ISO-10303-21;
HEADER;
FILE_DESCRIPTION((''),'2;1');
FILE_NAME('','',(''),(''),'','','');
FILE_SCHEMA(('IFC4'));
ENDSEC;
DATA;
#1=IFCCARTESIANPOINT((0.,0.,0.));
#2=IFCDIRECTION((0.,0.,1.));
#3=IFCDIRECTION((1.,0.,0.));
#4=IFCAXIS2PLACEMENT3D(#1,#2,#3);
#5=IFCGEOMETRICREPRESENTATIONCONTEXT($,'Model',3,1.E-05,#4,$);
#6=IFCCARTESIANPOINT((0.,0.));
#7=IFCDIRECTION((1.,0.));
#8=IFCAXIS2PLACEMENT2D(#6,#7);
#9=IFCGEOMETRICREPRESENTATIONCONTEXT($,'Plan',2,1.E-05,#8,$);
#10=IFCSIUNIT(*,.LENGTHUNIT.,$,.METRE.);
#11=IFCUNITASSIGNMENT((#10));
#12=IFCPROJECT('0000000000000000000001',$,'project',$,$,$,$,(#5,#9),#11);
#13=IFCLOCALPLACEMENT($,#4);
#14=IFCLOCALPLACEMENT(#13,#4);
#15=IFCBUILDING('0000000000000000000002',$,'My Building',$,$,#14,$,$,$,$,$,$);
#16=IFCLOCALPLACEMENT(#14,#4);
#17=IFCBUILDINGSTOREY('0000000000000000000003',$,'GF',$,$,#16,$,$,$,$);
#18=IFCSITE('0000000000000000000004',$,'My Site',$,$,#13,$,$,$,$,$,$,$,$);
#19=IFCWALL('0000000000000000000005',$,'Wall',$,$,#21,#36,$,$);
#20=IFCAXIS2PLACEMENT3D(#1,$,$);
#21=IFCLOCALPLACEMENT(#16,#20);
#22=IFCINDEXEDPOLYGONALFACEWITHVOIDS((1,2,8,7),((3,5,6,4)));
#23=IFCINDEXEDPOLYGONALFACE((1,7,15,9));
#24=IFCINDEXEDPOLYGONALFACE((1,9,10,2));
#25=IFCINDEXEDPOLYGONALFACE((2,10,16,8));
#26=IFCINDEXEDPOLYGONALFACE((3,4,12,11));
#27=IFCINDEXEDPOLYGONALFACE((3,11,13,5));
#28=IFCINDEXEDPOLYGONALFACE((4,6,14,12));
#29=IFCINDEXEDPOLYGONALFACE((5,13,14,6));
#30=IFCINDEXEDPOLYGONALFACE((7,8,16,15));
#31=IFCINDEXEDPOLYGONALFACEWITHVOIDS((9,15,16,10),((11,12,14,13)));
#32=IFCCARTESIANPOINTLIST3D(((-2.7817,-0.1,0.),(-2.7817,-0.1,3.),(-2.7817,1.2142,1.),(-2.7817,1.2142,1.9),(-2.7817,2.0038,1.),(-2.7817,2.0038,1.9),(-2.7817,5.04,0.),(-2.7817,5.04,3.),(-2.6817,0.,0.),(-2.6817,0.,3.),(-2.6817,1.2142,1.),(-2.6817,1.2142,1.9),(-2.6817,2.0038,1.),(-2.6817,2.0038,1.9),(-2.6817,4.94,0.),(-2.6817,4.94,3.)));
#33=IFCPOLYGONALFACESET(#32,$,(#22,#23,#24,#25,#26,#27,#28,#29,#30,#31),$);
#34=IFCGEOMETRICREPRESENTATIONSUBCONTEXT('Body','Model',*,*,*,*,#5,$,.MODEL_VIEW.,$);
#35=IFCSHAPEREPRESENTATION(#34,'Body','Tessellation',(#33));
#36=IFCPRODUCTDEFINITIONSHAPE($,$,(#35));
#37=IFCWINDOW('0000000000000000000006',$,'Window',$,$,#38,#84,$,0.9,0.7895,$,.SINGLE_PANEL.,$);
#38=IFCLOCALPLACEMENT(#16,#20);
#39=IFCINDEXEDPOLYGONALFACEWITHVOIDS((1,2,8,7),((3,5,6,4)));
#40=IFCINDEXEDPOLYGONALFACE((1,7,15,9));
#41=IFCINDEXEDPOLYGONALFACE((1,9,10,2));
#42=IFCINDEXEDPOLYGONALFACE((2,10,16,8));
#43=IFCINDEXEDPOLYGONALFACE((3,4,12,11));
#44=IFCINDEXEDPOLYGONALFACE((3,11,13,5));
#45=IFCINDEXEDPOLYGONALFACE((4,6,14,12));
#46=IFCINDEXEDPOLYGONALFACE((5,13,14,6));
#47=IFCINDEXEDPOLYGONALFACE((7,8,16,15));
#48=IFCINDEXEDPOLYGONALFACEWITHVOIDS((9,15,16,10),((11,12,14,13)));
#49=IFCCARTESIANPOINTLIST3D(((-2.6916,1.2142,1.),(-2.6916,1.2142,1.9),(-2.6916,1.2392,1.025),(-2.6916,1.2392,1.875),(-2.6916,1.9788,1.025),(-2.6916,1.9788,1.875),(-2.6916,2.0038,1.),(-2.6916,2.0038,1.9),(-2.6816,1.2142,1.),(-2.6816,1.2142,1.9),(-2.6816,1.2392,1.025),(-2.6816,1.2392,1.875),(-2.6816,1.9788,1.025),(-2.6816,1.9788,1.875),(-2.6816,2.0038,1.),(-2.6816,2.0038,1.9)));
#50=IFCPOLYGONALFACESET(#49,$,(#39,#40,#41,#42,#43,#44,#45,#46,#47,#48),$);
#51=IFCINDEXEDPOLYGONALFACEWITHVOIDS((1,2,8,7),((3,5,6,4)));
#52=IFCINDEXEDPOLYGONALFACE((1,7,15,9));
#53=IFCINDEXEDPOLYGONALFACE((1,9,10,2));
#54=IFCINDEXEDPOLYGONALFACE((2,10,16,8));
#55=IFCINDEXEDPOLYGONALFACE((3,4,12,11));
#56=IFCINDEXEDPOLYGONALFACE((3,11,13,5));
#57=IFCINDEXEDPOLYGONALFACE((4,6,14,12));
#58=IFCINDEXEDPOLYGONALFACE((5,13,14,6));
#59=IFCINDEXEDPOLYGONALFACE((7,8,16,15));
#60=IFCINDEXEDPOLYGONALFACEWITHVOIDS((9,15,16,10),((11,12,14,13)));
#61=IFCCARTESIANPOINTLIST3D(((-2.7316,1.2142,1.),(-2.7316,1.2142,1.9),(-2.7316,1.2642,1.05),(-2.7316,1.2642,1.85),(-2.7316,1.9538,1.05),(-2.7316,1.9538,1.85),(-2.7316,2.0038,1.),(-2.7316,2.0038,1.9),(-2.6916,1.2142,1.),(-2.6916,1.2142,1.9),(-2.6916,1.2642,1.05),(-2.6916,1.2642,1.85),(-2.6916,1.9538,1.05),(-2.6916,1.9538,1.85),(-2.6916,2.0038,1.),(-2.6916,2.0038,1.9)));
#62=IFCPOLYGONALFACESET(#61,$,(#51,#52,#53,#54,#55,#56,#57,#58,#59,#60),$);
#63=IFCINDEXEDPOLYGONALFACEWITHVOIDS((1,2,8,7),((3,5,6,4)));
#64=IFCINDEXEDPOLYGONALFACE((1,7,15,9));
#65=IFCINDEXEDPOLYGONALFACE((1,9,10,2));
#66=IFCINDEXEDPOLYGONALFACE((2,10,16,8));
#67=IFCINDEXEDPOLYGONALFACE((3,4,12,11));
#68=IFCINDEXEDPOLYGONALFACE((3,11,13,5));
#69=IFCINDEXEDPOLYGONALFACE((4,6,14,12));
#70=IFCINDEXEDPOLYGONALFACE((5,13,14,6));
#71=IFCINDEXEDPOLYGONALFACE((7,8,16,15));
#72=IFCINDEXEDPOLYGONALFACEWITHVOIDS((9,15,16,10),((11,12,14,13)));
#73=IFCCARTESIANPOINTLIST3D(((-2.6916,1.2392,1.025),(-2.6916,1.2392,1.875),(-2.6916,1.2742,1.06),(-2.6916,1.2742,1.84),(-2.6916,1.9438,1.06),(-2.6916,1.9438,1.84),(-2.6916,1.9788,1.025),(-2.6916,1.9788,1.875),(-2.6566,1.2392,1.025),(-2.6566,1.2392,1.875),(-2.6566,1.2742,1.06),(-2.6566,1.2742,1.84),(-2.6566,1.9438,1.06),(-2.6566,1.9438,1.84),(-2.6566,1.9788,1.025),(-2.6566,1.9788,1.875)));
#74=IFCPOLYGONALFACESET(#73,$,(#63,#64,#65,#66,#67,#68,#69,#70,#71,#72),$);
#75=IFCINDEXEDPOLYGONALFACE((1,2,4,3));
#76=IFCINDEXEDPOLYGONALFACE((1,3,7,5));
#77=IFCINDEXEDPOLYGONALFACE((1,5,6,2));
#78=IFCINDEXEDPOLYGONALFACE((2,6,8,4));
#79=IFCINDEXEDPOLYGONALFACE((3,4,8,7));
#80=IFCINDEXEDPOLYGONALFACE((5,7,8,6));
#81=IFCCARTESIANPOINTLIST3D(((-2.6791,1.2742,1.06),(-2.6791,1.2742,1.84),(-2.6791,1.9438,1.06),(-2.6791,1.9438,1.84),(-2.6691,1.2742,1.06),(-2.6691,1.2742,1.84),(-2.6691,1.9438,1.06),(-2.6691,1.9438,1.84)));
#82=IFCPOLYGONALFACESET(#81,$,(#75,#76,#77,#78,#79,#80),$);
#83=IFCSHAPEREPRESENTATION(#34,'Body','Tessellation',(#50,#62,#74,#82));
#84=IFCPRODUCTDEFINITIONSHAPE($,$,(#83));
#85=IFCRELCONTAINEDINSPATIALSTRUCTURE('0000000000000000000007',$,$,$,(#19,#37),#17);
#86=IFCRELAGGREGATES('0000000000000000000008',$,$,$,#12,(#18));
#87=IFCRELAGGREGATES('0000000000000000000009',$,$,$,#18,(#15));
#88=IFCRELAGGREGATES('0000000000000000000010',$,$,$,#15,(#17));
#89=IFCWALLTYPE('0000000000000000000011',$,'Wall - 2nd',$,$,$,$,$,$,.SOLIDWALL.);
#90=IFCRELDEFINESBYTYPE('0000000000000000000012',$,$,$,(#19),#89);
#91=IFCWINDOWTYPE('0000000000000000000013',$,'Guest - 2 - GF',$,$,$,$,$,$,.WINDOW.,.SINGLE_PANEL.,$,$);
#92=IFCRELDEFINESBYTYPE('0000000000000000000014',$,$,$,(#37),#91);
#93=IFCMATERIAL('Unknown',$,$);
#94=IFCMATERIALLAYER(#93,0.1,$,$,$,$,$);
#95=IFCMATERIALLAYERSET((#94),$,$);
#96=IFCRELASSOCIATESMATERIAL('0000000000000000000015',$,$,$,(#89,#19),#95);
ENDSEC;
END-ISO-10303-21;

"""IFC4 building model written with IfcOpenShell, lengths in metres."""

from ifc_helpers import new_model, entity, si_unit, frame, origin_with_axes, origin_2d_with_axis, place, context, subcontext, project, spatial, line, indexed_curve, outline, extrude, shape, source, transform, mapped, material, layer, layer_set, layer_usage, type_object, type_shapes, element, fill, save


model = new_model("IFC4")

# Units and contexts
model_context = context("Model", 3, precision=1e-05, world=origin_with_axes())
plan_context = context("Plan", 2, precision=1e-05, world=origin_2d_with_axis())
body_context_1 = subcontext(model_context, "Body", "Model", "MODEL_VIEW")
body_context_2 = subcontext(plan_context, "Body", "Plan", "PLAN_VIEW")
ifc_project = project(units=[si_unit("LENGTHUNIT", "METRE")], contexts=[model_context, plan_context])

# Site, building, storey
site_placement = place(None, origin_with_axes())
site = spatial("IfcSite", under=ifc_project, at=site_placement, Name="My Site")
building_placement = place(site_placement, origin_with_axes())
building = spatial("IfcBuilding", under=site, at=building_placement, Name="My Building")
storey_placement = place(building_placement, origin_with_axes())
storey = spatial("IfcBuildingStorey", under=building, at=storey_placement, Name="GF")

# Shared definitions
ifc_material = material(Name="Unknown")

# Shared definitions
ifc_layer_1 = layer(ifc_material, 0.1)
ifc_layer_set_1 = layer_set([ifc_layer_1])
wall_type = type_object("IfcWallType", Name="Wall - 2nd", PredefinedType="SOLIDWALL", material=ifc_layer_set_1)

# Wall, opening, window
ifc_layer_usage_1 = layer_usage(ifc_layer_set_1, "AXIS2", "POSITIVE", 0.0)
wall_1_placement = place(storey_placement, frame((-2.7817, 5.04, 0.0), z_axis=(0.0, 0.0, 1.0), x_axis=(0.0, -1.0, 0.0)))
wall_1 = element("IfcWall", 1, at=wall_1_placement, inside=storey, type_object=wall_type, material=ifc_layer_usage_1, Name="Wall", context=body_context_1, shape_type="SweptSolid", body=[
    extrude(outline(indexed_curve([(0.0, 0.0), (0.1, 0.1), (5.04, 0.1), (5.14, 0.0)], segments=[line(1, 2, 3, 4, 1)])), origin_with_axes(), (0.0, 0.0, 1.0), 3.0),
])
shared_shape_1 = source(origin_with_axes(), body_context_1, "Body", "SweptSolid", [
    extrude(outline(indexed_curve([(0.0, 0.0), (0.7895, 0.0), (0.7895, 0.9), (0.0, 0.9)], segments=[line(1, 2, 3, 4, 1)])), frame((0.0, -0.6, 0.0), z_axis=(0.0, -1.0, 0.0), x_axis=(1.0, 0.0, 0.0)), (0.0, 0.0, -1.0), 1.2),
])
opening_1_placement = place(wall_1_placement, frame((3.0362, 0.0, 1.0), z_axis=(0.0, 0.0, 1.0), x_axis=(1.0, 0.0, 0.0)))
opening_1 = element("IfcOpeningElement", 2, at=opening_1_placement, cuts=wall_1, PredefinedType="OPENING", context=body_context_1, shape_type="MappedRepresentation", body=[
    mapped(shared_shape_1, transform((0.0, 0.0, 0.0), x_axis=(1.0, 0.0, 0.0), y_axis=(0.0, 1.0, 0.0), z_axis=(0.0, 0.0, 1.0), scale=1.0)),
])
window_type_1 = type_object("IfcWindowType", Name="Guest - 2 - GF", PartitioningType="SINGLE_PANEL", PredefinedType="WINDOW")
shared_shape_2 = source(origin_with_axes(), body_context_1, "Body", "SweptSolid", [
    extrude(outline(indexed_curve([(0.0, 0.0), (0.7895, 0.0), (0.7895, 0.9), (0.0, 0.9)], segments=[line(1, 2, 3, 4, 1)]), holes=[indexed_curve([(0.025, 0.025), (0.7645, 0.025), (0.7645, 0.875), (0.025, 0.875)], segments=[line(1, 2, 3, 4, 1)])]), frame((0.0, 0.09, 0.0), z_axis=(0.0, -1.0, 0.0), x_axis=(1.0, 0.0, 0.0)), (0.0, 0.0, -1.0), 0.01),
    extrude(outline(indexed_curve([(0.0, 0.0), (0.7895, 0.0), (0.7895, 0.9), (0.0, 0.9)], segments=[line(1, 2, 3, 4, 1)]), holes=[indexed_curve([(0.05, 0.05), (0.7395, 0.05), (0.7395, 0.85), (0.05, 0.85)], segments=[line(1, 2, 3, 4, 1)])]), frame((0.0, 0.05, 0.0), z_axis=(0.0, -1.0, 0.0), x_axis=(1.0, 0.0, 0.0)), (0.0, 0.0, -1.0), 0.04),
    extrude(outline(indexed_curve([(0.0, 0.0), (0.7395, 0.0), (0.7395, 0.85), (0.0, 0.85)], segments=[line(1, 2, 3, 4, 1)]), holes=[indexed_curve([(0.035, 0.035), (0.7045, 0.035), (0.7045, 0.815), (0.035, 0.815)], segments=[line(1, 2, 3, 4, 1)])]), frame((0.025, 0.09, 0.025), z_axis=(0.0, -1.0, 0.0), x_axis=(1.0, 0.0, 0.0)), (0.0, 0.0, -1.0), 0.035),
    extrude(outline(indexed_curve([(0.035, 0.035), (0.7045, 0.035), (0.7045, 0.815), (0.035, 0.815)], segments=[line(1, 2, 3, 4, 1)])), frame((0.025, 0.1025, 0.025), z_axis=(0.0, -1.0, 0.0), x_axis=(1.0, 0.0, 0.0)), (0.0, 0.0, -1.0), 0.01),
])
shared_shape_3 = source(origin_with_axes(), body_context_2, "Body", "Curve2D", [
    entity("IfcIndexedPolyCurve", entity("IfcCartesianPointList2D", [[0.05, 0.05], [0.7395, 0.05]])),
    entity("IfcIndexedPolyCurve", entity("IfcCartesianPointList2D", [[0.0, 0.1], [0.025, 0.1], [0.025, 0.09], [0.05, 0.09], [0.05, 0.05], [0.0, 0.05]]), [entity("IfcLineIndex", [1, 2, 3, 4, 5, 6, 1])]),
    entity("IfcIndexedPolyCurve", entity("IfcCartesianPointList2D", [[0.7895, 0.1], [0.7645, 0.1], [0.7645, 0.09], [0.7395, 0.09], [0.7395, 0.05], [0.7895, 0.05]]), [entity("IfcLineIndex", [1, 2, 3, 4, 5, 6, 1])]),
    entity("IfcIndexedPolyCurve", entity("IfcCartesianPointList2D", [[0.025, 0.09], [0.06, 0.09], [0.06, 0.125], [0.025, 0.125]]), [entity("IfcLineIndex", [1, 2, 3, 4, 1])]),
    entity("IfcIndexedPolyCurve", entity("IfcCartesianPointList2D", [[0.7645, 0.09], [0.7295, 0.09], [0.7295, 0.125], [0.7645, 0.125]]), [entity("IfcLineIndex", [1, 2, 3, 4, 1])]),
    entity("IfcIndexedPolyCurve", entity("IfcCartesianPointList2D", [[0.06, 0.09], [0.7295, 0.09]])),
    entity("IfcIndexedPolyCurve", entity("IfcCartesianPointList2D", [[0.06, 0.125], [0.7295, 0.125]])),
    entity("IfcIndexedPolyCurve", entity("IfcCartesianPointList2D", [[0.06, 0.1075], [0.7295, 0.1075]])),
])
type_shapes(window_type_1, [shared_shape_2, shared_shape_3])
window_1_placement = place(opening_1_placement, frame((0.0, 0.0, 0.0), z_axis=(0.0, 0.0, 1.0), x_axis=(1.0, 0.0, 0.0)))
window_1 = element("IfcWindow", 3, at=window_1_placement, inside=storey, type_object=window_type_1, Name="Window", OverallHeight=0.9, OverallWidth=0.7895, PartitioningType="SINGLE_PANEL", shapes=[
    shape(body_context_1, "Body", "MappedRepresentation", [mapped(shared_shape_2, transform((0.0, 0.0, 0.0), x_axis=(1.0, 0.0, 0.0), y_axis=(0.0, 1.0, 0.0), z_axis=(0.0, 0.0, 1.0), scale=1.0))]),
    shape(body_context_2, "Body", "MappedRepresentation", [mapped(shared_shape_3, transform((0.0, 0.0, 0.0), x_axis=(1.0, 0.0, 0.0), y_axis=(0.0, 1.0, 0.0), z_axis=(0.0, 0.0, 1.0), scale=1.0))]),
])
fill(opening_1, window_1)

save(model, "model.ifc")
